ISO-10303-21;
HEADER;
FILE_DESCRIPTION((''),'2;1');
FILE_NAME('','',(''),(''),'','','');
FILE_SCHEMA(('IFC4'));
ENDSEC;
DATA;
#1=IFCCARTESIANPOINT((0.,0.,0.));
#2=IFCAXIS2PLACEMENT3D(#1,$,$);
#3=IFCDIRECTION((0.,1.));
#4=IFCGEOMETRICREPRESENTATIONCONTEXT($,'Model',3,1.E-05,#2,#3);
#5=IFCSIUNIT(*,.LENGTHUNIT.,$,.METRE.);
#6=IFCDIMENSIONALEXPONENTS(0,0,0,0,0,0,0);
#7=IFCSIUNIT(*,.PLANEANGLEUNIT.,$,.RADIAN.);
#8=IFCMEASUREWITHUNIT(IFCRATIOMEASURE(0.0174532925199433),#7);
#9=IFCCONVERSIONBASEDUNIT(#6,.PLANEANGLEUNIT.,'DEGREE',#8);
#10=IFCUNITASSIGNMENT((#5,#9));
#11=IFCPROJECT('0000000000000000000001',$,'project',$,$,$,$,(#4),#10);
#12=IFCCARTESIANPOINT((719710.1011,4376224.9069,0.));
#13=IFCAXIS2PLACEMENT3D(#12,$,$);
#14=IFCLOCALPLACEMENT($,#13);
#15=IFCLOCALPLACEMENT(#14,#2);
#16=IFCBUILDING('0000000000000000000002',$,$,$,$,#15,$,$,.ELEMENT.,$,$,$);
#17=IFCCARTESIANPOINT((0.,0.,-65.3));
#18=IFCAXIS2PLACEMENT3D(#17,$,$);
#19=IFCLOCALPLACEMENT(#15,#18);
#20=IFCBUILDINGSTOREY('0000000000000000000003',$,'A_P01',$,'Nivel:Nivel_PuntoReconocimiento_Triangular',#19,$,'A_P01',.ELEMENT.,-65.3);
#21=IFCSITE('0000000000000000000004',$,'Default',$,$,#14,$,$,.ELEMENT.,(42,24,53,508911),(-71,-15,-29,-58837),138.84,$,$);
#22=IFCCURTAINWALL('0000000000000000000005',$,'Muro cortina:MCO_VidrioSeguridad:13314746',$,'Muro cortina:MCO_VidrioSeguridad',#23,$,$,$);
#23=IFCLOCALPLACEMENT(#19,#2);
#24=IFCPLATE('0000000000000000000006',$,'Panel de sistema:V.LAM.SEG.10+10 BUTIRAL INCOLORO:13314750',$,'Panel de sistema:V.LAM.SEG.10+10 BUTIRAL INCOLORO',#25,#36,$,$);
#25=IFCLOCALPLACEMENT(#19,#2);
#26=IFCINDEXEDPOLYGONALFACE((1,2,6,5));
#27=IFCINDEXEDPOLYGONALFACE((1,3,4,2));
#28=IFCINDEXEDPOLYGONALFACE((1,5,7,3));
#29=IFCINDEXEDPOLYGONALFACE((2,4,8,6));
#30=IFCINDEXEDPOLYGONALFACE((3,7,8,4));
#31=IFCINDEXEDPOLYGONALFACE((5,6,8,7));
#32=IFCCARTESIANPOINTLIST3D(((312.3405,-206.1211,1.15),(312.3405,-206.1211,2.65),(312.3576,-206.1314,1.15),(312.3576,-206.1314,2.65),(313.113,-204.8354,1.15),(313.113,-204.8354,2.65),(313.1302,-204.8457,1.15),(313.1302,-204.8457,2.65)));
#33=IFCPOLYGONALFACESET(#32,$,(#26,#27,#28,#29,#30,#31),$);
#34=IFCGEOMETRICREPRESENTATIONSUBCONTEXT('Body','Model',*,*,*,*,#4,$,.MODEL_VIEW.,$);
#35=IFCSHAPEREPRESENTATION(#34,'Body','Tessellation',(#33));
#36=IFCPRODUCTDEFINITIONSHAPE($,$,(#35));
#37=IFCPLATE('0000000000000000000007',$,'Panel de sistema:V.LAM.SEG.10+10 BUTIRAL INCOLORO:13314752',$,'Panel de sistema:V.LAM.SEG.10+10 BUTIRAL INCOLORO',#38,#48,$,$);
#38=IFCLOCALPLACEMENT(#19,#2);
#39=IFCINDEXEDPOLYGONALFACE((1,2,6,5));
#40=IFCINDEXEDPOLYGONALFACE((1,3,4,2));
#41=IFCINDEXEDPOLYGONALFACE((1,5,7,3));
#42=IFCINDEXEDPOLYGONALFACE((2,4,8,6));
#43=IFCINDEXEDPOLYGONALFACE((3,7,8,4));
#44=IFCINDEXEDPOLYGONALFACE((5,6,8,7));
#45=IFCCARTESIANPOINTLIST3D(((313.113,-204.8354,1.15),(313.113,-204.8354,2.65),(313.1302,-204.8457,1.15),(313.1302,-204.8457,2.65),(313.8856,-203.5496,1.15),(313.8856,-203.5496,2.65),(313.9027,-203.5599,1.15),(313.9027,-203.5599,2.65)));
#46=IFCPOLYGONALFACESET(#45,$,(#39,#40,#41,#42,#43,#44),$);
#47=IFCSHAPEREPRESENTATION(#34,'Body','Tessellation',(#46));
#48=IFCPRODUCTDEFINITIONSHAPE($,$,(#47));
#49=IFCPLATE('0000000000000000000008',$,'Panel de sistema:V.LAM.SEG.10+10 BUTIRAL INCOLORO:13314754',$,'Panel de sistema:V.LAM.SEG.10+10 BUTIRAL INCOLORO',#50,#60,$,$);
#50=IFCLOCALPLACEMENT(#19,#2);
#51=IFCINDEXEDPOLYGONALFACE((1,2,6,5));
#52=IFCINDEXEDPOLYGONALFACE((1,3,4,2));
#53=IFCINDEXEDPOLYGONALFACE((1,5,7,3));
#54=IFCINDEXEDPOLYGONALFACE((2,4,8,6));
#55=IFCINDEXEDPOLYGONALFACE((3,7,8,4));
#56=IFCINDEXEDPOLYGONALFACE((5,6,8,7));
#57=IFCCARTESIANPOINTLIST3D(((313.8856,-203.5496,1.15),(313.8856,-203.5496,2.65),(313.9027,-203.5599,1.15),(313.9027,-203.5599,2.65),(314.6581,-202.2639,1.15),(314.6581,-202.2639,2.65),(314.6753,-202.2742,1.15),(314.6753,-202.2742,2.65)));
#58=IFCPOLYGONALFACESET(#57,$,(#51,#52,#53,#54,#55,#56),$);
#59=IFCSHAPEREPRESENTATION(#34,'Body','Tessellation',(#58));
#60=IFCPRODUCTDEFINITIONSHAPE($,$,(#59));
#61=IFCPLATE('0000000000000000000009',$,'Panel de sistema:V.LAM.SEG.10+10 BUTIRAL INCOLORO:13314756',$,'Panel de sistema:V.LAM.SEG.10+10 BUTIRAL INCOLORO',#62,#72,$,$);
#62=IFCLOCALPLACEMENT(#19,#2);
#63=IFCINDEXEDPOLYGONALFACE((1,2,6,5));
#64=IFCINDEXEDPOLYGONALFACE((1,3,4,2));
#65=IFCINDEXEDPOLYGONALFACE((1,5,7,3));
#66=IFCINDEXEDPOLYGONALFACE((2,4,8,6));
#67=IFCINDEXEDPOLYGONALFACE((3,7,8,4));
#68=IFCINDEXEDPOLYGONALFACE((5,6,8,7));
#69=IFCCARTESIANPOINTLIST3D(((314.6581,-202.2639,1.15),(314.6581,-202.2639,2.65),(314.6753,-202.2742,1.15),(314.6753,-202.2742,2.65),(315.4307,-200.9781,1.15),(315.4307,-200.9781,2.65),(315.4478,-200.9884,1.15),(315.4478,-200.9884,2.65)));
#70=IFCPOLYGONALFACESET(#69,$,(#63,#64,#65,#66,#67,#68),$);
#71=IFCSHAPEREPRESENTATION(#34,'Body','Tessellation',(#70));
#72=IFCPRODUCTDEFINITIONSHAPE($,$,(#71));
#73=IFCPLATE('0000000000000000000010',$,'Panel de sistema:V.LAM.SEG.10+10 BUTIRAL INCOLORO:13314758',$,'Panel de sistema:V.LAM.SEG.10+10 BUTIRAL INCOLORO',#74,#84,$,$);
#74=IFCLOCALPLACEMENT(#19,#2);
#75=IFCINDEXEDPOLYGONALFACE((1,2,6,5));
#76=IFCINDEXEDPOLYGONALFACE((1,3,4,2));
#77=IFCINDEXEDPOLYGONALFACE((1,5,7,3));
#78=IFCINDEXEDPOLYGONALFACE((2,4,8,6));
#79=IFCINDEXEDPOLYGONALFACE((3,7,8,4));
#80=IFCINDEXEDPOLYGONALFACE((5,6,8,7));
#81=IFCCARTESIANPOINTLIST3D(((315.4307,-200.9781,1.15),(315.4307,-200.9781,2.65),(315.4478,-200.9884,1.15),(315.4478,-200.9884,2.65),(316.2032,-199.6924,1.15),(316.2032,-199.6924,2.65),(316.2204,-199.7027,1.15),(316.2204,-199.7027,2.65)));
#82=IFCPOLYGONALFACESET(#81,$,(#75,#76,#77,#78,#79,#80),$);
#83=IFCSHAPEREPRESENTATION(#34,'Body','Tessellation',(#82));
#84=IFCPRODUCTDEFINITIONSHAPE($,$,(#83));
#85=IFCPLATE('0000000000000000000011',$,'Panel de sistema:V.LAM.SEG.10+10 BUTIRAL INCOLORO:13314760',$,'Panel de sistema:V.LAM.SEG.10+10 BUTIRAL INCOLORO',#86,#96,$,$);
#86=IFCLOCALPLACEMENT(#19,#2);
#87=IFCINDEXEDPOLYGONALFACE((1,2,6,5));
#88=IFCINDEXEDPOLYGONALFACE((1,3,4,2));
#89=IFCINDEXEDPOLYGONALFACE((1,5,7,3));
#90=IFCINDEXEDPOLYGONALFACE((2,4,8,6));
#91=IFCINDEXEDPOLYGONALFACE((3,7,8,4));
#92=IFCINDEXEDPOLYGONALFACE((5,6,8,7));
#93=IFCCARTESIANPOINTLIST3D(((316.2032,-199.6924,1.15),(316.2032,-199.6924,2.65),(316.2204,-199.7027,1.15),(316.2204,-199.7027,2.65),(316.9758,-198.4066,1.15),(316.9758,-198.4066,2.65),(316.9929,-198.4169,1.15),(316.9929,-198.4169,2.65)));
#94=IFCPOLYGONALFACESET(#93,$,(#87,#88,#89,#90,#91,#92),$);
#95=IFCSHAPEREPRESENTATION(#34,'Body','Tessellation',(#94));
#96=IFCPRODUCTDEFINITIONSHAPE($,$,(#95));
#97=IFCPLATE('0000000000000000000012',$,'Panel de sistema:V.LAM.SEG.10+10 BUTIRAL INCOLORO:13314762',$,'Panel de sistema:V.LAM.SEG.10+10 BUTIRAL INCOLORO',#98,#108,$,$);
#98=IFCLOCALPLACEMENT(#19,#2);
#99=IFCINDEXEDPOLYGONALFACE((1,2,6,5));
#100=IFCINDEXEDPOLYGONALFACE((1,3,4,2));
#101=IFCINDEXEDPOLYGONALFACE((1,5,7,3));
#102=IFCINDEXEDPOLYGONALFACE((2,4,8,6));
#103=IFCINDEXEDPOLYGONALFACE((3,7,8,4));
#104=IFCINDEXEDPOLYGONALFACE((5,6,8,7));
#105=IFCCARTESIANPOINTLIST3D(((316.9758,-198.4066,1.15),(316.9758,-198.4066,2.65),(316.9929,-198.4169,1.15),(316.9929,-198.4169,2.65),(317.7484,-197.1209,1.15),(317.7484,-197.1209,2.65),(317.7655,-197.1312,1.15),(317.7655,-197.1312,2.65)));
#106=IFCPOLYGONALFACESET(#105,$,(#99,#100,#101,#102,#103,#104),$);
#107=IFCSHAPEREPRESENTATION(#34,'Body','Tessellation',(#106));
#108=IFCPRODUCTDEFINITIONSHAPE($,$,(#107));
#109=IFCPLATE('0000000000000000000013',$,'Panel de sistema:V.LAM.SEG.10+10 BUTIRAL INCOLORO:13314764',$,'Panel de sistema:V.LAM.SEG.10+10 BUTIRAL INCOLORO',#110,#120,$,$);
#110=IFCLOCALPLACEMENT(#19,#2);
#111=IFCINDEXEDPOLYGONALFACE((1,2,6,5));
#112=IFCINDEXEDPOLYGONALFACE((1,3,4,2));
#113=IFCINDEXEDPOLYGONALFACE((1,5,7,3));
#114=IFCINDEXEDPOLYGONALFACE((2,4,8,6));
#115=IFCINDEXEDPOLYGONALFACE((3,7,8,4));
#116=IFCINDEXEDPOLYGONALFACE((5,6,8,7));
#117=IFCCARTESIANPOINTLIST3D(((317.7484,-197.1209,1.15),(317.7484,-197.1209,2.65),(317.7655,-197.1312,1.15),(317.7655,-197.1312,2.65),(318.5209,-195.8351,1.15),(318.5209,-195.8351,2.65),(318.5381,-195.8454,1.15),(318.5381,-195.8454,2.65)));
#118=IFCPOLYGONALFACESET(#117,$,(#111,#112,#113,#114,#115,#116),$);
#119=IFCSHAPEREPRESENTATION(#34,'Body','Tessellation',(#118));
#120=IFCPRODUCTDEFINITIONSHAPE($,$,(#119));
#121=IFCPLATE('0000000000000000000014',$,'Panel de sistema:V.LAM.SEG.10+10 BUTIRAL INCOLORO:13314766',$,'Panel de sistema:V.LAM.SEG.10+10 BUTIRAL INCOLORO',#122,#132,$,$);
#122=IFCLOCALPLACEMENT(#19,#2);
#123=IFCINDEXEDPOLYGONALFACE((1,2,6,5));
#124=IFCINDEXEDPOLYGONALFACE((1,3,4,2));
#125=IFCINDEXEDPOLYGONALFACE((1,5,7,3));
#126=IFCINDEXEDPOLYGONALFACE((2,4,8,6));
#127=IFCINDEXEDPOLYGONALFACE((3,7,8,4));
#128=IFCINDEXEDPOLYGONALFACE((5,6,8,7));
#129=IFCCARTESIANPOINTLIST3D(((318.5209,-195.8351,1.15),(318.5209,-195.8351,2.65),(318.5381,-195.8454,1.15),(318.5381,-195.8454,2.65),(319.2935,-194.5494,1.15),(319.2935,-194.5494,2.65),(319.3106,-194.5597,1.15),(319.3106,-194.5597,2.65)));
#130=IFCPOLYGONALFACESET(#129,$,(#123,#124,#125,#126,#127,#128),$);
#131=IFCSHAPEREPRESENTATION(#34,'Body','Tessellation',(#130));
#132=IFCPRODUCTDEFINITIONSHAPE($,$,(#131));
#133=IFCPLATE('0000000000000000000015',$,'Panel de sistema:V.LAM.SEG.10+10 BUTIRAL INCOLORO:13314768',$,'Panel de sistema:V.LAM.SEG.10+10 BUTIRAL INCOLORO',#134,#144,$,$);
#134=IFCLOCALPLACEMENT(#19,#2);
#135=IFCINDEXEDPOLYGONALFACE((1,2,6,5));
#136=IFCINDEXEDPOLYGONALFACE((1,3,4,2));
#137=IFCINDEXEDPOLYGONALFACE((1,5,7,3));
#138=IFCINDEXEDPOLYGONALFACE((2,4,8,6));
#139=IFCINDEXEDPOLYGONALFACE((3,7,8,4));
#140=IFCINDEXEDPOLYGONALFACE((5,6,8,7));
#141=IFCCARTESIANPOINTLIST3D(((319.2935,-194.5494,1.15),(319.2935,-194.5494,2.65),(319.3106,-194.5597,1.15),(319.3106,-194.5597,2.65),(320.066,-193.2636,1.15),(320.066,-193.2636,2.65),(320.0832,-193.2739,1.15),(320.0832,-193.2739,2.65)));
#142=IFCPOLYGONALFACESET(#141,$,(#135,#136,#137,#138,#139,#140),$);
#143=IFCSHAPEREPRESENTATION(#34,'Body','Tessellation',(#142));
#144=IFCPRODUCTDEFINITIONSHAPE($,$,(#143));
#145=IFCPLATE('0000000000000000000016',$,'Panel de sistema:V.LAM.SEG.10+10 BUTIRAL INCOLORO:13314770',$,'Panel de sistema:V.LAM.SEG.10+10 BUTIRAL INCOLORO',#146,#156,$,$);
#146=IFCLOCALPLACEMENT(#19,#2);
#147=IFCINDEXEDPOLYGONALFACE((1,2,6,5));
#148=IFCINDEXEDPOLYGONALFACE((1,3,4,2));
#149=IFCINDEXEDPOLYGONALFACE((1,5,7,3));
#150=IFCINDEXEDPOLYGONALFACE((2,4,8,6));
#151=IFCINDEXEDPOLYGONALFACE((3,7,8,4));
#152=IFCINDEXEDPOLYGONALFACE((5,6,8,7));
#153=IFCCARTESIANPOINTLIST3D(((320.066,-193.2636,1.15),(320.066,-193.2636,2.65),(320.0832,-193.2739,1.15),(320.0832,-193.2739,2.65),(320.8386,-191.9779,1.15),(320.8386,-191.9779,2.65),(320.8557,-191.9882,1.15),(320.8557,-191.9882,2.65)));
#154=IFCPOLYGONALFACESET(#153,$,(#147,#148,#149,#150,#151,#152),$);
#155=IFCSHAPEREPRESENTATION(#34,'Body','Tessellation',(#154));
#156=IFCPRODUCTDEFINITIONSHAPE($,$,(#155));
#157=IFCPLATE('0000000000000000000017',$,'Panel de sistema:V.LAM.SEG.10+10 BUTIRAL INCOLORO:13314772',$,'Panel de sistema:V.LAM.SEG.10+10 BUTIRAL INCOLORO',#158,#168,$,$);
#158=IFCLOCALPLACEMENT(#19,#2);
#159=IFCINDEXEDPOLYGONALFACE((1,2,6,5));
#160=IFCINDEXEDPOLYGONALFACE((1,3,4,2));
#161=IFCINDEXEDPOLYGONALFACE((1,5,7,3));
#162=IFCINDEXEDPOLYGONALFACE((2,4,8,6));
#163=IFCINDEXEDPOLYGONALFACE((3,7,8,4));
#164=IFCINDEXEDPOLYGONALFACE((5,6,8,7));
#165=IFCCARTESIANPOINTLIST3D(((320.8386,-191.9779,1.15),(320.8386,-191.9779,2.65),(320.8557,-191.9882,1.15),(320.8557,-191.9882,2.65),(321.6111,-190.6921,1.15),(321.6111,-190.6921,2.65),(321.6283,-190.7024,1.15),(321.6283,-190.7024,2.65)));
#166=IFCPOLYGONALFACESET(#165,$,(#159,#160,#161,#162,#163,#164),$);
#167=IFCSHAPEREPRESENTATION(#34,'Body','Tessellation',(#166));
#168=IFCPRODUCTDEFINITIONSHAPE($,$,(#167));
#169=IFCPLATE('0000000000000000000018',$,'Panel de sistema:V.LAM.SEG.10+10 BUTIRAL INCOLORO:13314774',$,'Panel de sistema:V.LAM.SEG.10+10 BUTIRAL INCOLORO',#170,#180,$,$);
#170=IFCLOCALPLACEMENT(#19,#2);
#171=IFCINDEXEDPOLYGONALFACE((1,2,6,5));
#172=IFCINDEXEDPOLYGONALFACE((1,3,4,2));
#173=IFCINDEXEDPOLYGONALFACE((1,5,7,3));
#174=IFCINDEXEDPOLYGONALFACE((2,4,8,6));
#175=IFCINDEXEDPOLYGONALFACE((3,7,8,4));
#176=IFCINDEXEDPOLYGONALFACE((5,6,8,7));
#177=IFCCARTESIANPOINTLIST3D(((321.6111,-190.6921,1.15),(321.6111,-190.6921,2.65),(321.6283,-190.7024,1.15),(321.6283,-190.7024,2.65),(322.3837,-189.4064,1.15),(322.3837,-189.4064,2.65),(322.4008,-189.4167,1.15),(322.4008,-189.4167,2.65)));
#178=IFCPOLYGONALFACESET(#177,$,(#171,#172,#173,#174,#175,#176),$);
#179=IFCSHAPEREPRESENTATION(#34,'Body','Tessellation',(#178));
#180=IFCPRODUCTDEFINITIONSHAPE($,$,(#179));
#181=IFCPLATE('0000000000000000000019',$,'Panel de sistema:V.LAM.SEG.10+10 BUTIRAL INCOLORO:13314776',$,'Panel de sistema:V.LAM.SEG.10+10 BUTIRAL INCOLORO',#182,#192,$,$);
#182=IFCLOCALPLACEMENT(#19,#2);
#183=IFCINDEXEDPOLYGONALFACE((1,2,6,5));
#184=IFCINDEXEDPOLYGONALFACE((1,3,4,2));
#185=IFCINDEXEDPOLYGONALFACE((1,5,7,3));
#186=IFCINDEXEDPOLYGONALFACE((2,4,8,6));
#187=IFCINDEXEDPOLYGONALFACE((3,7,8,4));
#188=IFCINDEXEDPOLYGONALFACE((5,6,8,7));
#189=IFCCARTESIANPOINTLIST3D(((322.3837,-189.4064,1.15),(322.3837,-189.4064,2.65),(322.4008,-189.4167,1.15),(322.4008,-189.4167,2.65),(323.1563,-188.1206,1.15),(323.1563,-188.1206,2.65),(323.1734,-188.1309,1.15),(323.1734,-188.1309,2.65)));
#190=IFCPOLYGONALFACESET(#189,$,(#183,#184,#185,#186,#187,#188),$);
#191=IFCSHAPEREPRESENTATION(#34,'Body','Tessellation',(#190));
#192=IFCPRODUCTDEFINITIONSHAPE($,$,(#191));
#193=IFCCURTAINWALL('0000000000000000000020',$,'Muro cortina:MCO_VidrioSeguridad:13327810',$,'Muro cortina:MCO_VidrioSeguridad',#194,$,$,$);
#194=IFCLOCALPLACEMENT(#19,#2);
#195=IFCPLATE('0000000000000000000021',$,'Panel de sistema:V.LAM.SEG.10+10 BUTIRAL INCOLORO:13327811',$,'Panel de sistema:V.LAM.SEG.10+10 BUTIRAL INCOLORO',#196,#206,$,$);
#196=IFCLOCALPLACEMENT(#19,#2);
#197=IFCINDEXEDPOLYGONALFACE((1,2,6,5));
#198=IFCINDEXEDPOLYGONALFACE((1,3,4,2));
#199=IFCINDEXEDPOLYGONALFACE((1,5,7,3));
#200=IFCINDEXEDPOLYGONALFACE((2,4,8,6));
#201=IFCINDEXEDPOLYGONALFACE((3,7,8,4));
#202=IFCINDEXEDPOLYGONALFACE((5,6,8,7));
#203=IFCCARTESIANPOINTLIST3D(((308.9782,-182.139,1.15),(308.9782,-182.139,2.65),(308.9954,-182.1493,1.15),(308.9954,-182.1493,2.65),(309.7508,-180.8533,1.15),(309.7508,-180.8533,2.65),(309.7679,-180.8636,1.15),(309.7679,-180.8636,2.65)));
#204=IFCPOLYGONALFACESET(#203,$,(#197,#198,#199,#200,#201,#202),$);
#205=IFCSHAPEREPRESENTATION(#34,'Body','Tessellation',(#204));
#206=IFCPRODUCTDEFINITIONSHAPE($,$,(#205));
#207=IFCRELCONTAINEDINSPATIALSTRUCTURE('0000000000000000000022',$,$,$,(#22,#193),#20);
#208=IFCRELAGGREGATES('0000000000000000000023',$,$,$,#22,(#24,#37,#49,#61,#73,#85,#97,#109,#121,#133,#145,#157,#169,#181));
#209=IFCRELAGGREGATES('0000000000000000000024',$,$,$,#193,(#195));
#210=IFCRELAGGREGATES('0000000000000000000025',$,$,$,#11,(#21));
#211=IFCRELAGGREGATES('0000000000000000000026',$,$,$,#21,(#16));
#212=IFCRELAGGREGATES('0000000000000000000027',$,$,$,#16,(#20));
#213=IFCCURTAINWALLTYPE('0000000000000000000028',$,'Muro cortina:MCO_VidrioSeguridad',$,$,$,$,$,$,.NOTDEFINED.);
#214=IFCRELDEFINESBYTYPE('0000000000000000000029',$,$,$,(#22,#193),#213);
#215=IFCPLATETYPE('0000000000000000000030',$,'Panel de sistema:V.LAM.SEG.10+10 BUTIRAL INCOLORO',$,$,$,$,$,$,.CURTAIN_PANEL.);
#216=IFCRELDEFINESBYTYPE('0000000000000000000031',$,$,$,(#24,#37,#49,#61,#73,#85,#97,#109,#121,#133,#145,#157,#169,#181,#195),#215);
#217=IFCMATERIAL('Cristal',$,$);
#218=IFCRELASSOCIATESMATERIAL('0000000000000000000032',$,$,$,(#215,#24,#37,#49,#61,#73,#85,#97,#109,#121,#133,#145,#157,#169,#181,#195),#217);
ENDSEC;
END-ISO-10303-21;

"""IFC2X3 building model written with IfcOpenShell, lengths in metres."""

from ifc_helpers import new_model, entity, si_unit, converted_unit, direction, frame, frame_2d, origin, place, context, subcontext, project, spatial, rectangle, extrude, source, transform, mapped, material, type_object, type_shapes, element, aggregate, save


model = new_model("IFC2X3")

# Units and contexts
model_context = context("Model", 3, precision=1e-05, world=origin(), true_north=direction((0.0, 1.0)))
body_context = subcontext(model_context, "Body", "Model", "MODEL_VIEW")
ifc_project = project(units=[si_unit("LENGTHUNIT", "METRE"), converted_unit("PLANEANGLEUNIT", "DEGREE", entity("IfcRatioMeasure", 0.0174532925199433), si_unit("PLANEANGLEUNIT", "RADIAN"), dimensions=[0, 0, 0, 0, 0, 0, 0])], contexts=[model_context])

# Site, building, storey
site_placement = place(None, frame((719710.1011, 4376224.9069, 0.0)))
site = spatial("IfcSite", under=ifc_project, at=site_placement, Name="Default", CompositionType="ELEMENT", RefLatitude=(42, 24, 53, 508911), RefLongitude=(-71, -15, -29, -58837), RefElevation=138.84)
building_placement = place(site_placement, origin())
building = spatial("IfcBuilding", under=site, at=building_placement, CompositionType="ELEMENT")
storey_placement = place(building_placement, frame((0.0, 0.0, -65.3)))
storey = spatial("IfcBuildingStorey", under=building, at=storey_placement, Name="A_P01", ObjectType="Nivel:Nivel_PuntoReconocimiento_Triangular", LongName="A_P01", CompositionType="ELEMENT", Elevation=-65.3)

# Shared definitions
curtain_wall_type = type_object("IfcCurtainWallType", Name="Muro cortina:MCO_VidrioSeguridad", PredefinedType="NOTDEFINED")
ifc_material_1 = material(Name="Cristal")

# Curtain walls, plates
curtain_wall_1_placement = place(storey_placement, frame((0.0, 0.0, 65.3)))
curtain_wall_1 = element("IfcCurtainWall", 1, at=curtain_wall_1_placement, inside=storey, type_object=curtain_wall_type, Name="Muro cortina:MCO_VidrioSeguridad:13314746", ObjectType="Muro cortina:MCO_VidrioSeguridad")
plate_type_1 = type_object("IfcPlateType", Name="Panel de sistema:V.LAM.SEG.10+10 BUTIRAL INCOLORO", PredefinedType="CURTAIN_PANEL", material=ifc_material_1)
shared_shape_1 = source(origin(), body_context, "Body", "SweptSolid", [
    extrude(rectangle(XDim=0.02, YDim=1.5, at=frame_2d((0.0, 0.0), x_axis=(1.0, 0.0))), frame((0.0, 0.0, 0.0), z_axis=(0.0, 0.0, 1.0), x_axis=(0.0, 1.0, 0.0)), (0.0, 0.0, 1.0), 1.5),
])
type_shapes(plate_type_1, [shared_shape_1])
plate_1_placement = place(curtain_wall_1_placement, frame((312.7353, -205.4834, -64.15), z_axis=(0.0, 0.0, 1.0), x_axis=(0.515038, 0.857167, 0.0)))
plate_1 = element("IfcPlate", 2, at=plate_1_placement, type_object=plate_type_1, material=ifc_material_1, Name="Panel de sistema:V.LAM.SEG.10+10 BUTIRAL INCOLORO:13314750", ObjectType="Panel de sistema:V.LAM.SEG.10+10 BUTIRAL INCOLORO", context=body_context, shape_type="MappedRepresentation", body=[
    mapped(shared_shape_1, transform((0.0, 0.0, 0.0), scale=1.0)),
])
plate_2_placement = place(curtain_wall_1_placement, frame((313.5079, -204.1976, -64.15), z_axis=(0.0, 0.0, 1.0), x_axis=(0.515038, 0.857167, 0.0)))
plate_2 = element("IfcPlate", 3, at=plate_2_placement, type_object=plate_type_1, material=ifc_material_1, Name="Panel de sistema:V.LAM.SEG.10+10 BUTIRAL INCOLORO:13314752", ObjectType="Panel de sistema:V.LAM.SEG.10+10 BUTIRAL INCOLORO", context=body_context, shape_type="MappedRepresentation", body=[
    mapped(shared_shape_1, transform((0.0, 0.0, 0.0), scale=1.0)),
])
plate_3_placement = place(curtain_wall_1_placement, frame((314.2804, -202.9119, -64.15), z_axis=(0.0, 0.0, 1.0), x_axis=(0.515038, 0.857167, 0.0)))
plate_3 = element("IfcPlate", 4, at=plate_3_placement, type_object=plate_type_1, material=ifc_material_1, Name="Panel de sistema:V.LAM.SEG.10+10 BUTIRAL INCOLORO:13314754", ObjectType="Panel de sistema:V.LAM.SEG.10+10 BUTIRAL INCOLORO", context=body_context, shape_type="MappedRepresentation", body=[
    mapped(shared_shape_1, transform((0.0, 0.0, 0.0), scale=1.0)),
])
plate_4_placement = place(curtain_wall_1_placement, frame((315.053, -201.6261, -64.15), z_axis=(0.0, 0.0, 1.0), x_axis=(0.515038, 0.857167, 0.0)))
plate_4 = element("IfcPlate", 5, at=plate_4_placement, type_object=plate_type_1, material=ifc_material_1, Name="Panel de sistema:V.LAM.SEG.10+10 BUTIRAL INCOLORO:13314756", ObjectType="Panel de sistema:V.LAM.SEG.10+10 BUTIRAL INCOLORO", context=body_context, shape_type="MappedRepresentation", body=[
    mapped(shared_shape_1, transform((0.0, 0.0, 0.0), scale=1.0)),
])
plate_5_placement = place(curtain_wall_1_placement, frame((315.8255, -200.3404, -64.15), z_axis=(0.0, 0.0, 1.0), x_axis=(0.515038, 0.857167, 0.0)))
plate_5 = element("IfcPlate", 6, at=plate_5_placement, type_object=plate_type_1, material=ifc_material_1, Name="Panel de sistema:V.LAM.SEG.10+10 BUTIRAL INCOLORO:13314758", ObjectType="Panel de sistema:V.LAM.SEG.10+10 BUTIRAL INCOLORO", context=body_context, shape_type="MappedRepresentation", body=[
    mapped(shared_shape_1, transform((0.0, 0.0, 0.0), scale=1.0)),
])
plate_6_placement = place(curtain_wall_1_placement, frame((316.5981, -199.0546, -64.15), z_axis=(0.0, 0.0, 1.0), x_axis=(0.515038, 0.857167, 0.0)))
plate_6 = element("IfcPlate", 7, at=plate_6_placement, type_object=plate_type_1, material=ifc_material_1, Name="Panel de sistema:V.LAM.SEG.10+10 BUTIRAL INCOLORO:13314760", ObjectType="Panel de sistema:V.LAM.SEG.10+10 BUTIRAL INCOLORO", context=body_context, shape_type="MappedRepresentation", body=[
    mapped(shared_shape_1, transform((0.0, 0.0, 0.0), scale=1.0)),
])
plate_7_placement = place(curtain_wall_1_placement, frame((317.3707, -197.7689, -64.15), z_axis=(0.0, 0.0, 1.0), x_axis=(0.515038, 0.857167, 0.0)))
plate_7 = element("IfcPlate", 8, at=plate_7_placement, type_object=plate_type_1, material=ifc_material_1, Name="Panel de sistema:V.LAM.SEG.10+10 BUTIRAL INCOLORO:13314762", ObjectType="Panel de sistema:V.LAM.SEG.10+10 BUTIRAL INCOLORO", context=body_context, shape_type="MappedRepresentation", body=[
    mapped(shared_shape_1, transform((0.0, 0.0, 0.0), scale=1.0)),
])
plate_8_placement = place(curtain_wall_1_placement, frame((318.1432, -196.4831, -64.15), z_axis=(0.0, 0.0, 1.0), x_axis=(0.515038, 0.857167, 0.0)))
plate_8 = element("IfcPlate", 9, at=plate_8_placement, type_object=plate_type_1, material=ifc_material_1, Name="Panel de sistema:V.LAM.SEG.10+10 BUTIRAL INCOLORO:13314764", ObjectType="Panel de sistema:V.LAM.SEG.10+10 BUTIRAL INCOLORO", context=body_context, shape_type="MappedRepresentation", body=[
    mapped(shared_shape_1, transform((0.0, 0.0, 0.0), scale=1.0)),
])
plate_9_placement = place(curtain_wall_1_placement, frame((318.9158, -195.1974, -64.15), z_axis=(0.0, 0.0, 1.0), x_axis=(0.515038, 0.857167, 0.0)))
plate_9 = element("IfcPlate", 10, at=plate_9_placement, type_object=plate_type_1, material=ifc_material_1, Name="Panel de sistema:V.LAM.SEG.10+10 BUTIRAL INCOLORO:13314766", ObjectType="Panel de sistema:V.LAM.SEG.10+10 BUTIRAL INCOLORO", context=body_context, shape_type="MappedRepresentation", body=[
    mapped(shared_shape_1, transform((0.0, 0.0, 0.0), scale=1.0)),
])
plate_10_placement = place(curtain_wall_1_placement, frame((319.6883, -193.9116, -64.15), z_axis=(0.0, 0.0, 1.0), x_axis=(0.515038, 0.857167, 0.0)))
plate_10 = element("IfcPlate", 11, at=plate_10_placement, type_object=plate_type_1, material=ifc_material_1, Name="Panel de sistema:V.LAM.SEG.10+10 BUTIRAL INCOLORO:13314768", ObjectType="Panel de sistema:V.LAM.SEG.10+10 BUTIRAL INCOLORO", context=body_context, shape_type="MappedRepresentation", body=[
    mapped(shared_shape_1, transform((0.0, 0.0, 0.0), scale=1.0)),
])
plate_11_placement = place(curtain_wall_1_placement, frame((320.4609, -192.6259, -64.15), z_axis=(0.0, 0.0, 1.0), x_axis=(0.515038, 0.857167, 0.0)))
plate_11 = element("IfcPlate", 12, at=plate_11_placement, type_object=plate_type_1, material=ifc_material_1, Name="Panel de sistema:V.LAM.SEG.10+10 BUTIRAL INCOLORO:13314770", ObjectType="Panel de sistema:V.LAM.SEG.10+10 BUTIRAL INCOLORO", context=body_context, shape_type="MappedRepresentation", body=[
    mapped(shared_shape_1, transform((0.0, 0.0, 0.0), scale=1.0)),
])
plate_12_placement = place(curtain_wall_1_placement, frame((321.2334, -191.3401, -64.15), z_axis=(0.0, 0.0, 1.0), x_axis=(0.515038, 0.857167, 0.0)))
plate_12 = element("IfcPlate", 13, at=plate_12_placement, type_object=plate_type_1, material=ifc_material_1, Name="Panel de sistema:V.LAM.SEG.10+10 BUTIRAL INCOLORO:13314772", ObjectType="Panel de sistema:V.LAM.SEG.10+10 BUTIRAL INCOLORO", context=body_context, shape_type="MappedRepresentation", body=[
    mapped(shared_shape_1, transform((0.0, 0.0, 0.0), scale=1.0)),
])
plate_13_placement = place(curtain_wall_1_placement, frame((322.006, -190.0544, -64.15), z_axis=(0.0, 0.0, 1.0), x_axis=(0.515038, 0.857167, 0.0)))
plate_13 = element("IfcPlate", 14, at=plate_13_placement, type_object=plate_type_1, material=ifc_material_1, Name="Panel de sistema:V.LAM.SEG.10+10 BUTIRAL INCOLORO:13314774", ObjectType="Panel de sistema:V.LAM.SEG.10+10 BUTIRAL INCOLORO", context=body_context, shape_type="MappedRepresentation", body=[
    mapped(shared_shape_1, transform((0.0, 0.0, 0.0), scale=1.0)),
])
plate_14_placement = place(curtain_wall_1_placement, frame((322.7786, -188.7686, -64.15), z_axis=(0.0, 0.0, 1.0), x_axis=(0.515038, 0.857167, 0.0)))
plate_14 = element("IfcPlate", 15, at=plate_14_placement, type_object=plate_type_1, material=ifc_material_1, Name="Panel de sistema:V.LAM.SEG.10+10 BUTIRAL INCOLORO:13314776", ObjectType="Panel de sistema:V.LAM.SEG.10+10 BUTIRAL INCOLORO", context=body_context, shape_type="MappedRepresentation", body=[
    mapped(shared_shape_1, transform((0.0, 0.0, 0.0), scale=1.0)),
])
curtain_wall_2_placement = place(storey_placement, frame((0.0, 0.0, 65.3)))
curtain_wall_2 = element("IfcCurtainWall", 16, at=curtain_wall_2_placement, inside=storey, type_object=curtain_wall_type, Name="Muro cortina:MCO_VidrioSeguridad:13327810", ObjectType="Muro cortina:MCO_VidrioSeguridad")
plate_15_placement = place(curtain_wall_2_placement, frame((309.3731, -181.5013, -64.15), z_axis=(0.0, 0.0, 1.0), x_axis=(0.515038, 0.857167, 0.0)))
plate_15 = element("IfcPlate", 17, at=plate_15_placement, type_object=plate_type_1, material=ifc_material_1, Name="Panel de sistema:V.LAM.SEG.10+10 BUTIRAL INCOLORO:13327811", ObjectType="Panel de sistema:V.LAM.SEG.10+10 BUTIRAL INCOLORO", context=body_context, shape_type="MappedRepresentation", body=[
    mapped(shared_shape_1, transform((0.0, 0.0, 0.0), scale=1.0)),
])

aggregate(curtain_wall_1, [plate_1, plate_2, plate_3, plate_4, plate_5, plate_6, plate_7, plate_8, plate_9, plate_10, plate_11, plate_12, plate_13, plate_14])
aggregate(curtain_wall_2, [plate_15])

save(model, "model.ifc")
